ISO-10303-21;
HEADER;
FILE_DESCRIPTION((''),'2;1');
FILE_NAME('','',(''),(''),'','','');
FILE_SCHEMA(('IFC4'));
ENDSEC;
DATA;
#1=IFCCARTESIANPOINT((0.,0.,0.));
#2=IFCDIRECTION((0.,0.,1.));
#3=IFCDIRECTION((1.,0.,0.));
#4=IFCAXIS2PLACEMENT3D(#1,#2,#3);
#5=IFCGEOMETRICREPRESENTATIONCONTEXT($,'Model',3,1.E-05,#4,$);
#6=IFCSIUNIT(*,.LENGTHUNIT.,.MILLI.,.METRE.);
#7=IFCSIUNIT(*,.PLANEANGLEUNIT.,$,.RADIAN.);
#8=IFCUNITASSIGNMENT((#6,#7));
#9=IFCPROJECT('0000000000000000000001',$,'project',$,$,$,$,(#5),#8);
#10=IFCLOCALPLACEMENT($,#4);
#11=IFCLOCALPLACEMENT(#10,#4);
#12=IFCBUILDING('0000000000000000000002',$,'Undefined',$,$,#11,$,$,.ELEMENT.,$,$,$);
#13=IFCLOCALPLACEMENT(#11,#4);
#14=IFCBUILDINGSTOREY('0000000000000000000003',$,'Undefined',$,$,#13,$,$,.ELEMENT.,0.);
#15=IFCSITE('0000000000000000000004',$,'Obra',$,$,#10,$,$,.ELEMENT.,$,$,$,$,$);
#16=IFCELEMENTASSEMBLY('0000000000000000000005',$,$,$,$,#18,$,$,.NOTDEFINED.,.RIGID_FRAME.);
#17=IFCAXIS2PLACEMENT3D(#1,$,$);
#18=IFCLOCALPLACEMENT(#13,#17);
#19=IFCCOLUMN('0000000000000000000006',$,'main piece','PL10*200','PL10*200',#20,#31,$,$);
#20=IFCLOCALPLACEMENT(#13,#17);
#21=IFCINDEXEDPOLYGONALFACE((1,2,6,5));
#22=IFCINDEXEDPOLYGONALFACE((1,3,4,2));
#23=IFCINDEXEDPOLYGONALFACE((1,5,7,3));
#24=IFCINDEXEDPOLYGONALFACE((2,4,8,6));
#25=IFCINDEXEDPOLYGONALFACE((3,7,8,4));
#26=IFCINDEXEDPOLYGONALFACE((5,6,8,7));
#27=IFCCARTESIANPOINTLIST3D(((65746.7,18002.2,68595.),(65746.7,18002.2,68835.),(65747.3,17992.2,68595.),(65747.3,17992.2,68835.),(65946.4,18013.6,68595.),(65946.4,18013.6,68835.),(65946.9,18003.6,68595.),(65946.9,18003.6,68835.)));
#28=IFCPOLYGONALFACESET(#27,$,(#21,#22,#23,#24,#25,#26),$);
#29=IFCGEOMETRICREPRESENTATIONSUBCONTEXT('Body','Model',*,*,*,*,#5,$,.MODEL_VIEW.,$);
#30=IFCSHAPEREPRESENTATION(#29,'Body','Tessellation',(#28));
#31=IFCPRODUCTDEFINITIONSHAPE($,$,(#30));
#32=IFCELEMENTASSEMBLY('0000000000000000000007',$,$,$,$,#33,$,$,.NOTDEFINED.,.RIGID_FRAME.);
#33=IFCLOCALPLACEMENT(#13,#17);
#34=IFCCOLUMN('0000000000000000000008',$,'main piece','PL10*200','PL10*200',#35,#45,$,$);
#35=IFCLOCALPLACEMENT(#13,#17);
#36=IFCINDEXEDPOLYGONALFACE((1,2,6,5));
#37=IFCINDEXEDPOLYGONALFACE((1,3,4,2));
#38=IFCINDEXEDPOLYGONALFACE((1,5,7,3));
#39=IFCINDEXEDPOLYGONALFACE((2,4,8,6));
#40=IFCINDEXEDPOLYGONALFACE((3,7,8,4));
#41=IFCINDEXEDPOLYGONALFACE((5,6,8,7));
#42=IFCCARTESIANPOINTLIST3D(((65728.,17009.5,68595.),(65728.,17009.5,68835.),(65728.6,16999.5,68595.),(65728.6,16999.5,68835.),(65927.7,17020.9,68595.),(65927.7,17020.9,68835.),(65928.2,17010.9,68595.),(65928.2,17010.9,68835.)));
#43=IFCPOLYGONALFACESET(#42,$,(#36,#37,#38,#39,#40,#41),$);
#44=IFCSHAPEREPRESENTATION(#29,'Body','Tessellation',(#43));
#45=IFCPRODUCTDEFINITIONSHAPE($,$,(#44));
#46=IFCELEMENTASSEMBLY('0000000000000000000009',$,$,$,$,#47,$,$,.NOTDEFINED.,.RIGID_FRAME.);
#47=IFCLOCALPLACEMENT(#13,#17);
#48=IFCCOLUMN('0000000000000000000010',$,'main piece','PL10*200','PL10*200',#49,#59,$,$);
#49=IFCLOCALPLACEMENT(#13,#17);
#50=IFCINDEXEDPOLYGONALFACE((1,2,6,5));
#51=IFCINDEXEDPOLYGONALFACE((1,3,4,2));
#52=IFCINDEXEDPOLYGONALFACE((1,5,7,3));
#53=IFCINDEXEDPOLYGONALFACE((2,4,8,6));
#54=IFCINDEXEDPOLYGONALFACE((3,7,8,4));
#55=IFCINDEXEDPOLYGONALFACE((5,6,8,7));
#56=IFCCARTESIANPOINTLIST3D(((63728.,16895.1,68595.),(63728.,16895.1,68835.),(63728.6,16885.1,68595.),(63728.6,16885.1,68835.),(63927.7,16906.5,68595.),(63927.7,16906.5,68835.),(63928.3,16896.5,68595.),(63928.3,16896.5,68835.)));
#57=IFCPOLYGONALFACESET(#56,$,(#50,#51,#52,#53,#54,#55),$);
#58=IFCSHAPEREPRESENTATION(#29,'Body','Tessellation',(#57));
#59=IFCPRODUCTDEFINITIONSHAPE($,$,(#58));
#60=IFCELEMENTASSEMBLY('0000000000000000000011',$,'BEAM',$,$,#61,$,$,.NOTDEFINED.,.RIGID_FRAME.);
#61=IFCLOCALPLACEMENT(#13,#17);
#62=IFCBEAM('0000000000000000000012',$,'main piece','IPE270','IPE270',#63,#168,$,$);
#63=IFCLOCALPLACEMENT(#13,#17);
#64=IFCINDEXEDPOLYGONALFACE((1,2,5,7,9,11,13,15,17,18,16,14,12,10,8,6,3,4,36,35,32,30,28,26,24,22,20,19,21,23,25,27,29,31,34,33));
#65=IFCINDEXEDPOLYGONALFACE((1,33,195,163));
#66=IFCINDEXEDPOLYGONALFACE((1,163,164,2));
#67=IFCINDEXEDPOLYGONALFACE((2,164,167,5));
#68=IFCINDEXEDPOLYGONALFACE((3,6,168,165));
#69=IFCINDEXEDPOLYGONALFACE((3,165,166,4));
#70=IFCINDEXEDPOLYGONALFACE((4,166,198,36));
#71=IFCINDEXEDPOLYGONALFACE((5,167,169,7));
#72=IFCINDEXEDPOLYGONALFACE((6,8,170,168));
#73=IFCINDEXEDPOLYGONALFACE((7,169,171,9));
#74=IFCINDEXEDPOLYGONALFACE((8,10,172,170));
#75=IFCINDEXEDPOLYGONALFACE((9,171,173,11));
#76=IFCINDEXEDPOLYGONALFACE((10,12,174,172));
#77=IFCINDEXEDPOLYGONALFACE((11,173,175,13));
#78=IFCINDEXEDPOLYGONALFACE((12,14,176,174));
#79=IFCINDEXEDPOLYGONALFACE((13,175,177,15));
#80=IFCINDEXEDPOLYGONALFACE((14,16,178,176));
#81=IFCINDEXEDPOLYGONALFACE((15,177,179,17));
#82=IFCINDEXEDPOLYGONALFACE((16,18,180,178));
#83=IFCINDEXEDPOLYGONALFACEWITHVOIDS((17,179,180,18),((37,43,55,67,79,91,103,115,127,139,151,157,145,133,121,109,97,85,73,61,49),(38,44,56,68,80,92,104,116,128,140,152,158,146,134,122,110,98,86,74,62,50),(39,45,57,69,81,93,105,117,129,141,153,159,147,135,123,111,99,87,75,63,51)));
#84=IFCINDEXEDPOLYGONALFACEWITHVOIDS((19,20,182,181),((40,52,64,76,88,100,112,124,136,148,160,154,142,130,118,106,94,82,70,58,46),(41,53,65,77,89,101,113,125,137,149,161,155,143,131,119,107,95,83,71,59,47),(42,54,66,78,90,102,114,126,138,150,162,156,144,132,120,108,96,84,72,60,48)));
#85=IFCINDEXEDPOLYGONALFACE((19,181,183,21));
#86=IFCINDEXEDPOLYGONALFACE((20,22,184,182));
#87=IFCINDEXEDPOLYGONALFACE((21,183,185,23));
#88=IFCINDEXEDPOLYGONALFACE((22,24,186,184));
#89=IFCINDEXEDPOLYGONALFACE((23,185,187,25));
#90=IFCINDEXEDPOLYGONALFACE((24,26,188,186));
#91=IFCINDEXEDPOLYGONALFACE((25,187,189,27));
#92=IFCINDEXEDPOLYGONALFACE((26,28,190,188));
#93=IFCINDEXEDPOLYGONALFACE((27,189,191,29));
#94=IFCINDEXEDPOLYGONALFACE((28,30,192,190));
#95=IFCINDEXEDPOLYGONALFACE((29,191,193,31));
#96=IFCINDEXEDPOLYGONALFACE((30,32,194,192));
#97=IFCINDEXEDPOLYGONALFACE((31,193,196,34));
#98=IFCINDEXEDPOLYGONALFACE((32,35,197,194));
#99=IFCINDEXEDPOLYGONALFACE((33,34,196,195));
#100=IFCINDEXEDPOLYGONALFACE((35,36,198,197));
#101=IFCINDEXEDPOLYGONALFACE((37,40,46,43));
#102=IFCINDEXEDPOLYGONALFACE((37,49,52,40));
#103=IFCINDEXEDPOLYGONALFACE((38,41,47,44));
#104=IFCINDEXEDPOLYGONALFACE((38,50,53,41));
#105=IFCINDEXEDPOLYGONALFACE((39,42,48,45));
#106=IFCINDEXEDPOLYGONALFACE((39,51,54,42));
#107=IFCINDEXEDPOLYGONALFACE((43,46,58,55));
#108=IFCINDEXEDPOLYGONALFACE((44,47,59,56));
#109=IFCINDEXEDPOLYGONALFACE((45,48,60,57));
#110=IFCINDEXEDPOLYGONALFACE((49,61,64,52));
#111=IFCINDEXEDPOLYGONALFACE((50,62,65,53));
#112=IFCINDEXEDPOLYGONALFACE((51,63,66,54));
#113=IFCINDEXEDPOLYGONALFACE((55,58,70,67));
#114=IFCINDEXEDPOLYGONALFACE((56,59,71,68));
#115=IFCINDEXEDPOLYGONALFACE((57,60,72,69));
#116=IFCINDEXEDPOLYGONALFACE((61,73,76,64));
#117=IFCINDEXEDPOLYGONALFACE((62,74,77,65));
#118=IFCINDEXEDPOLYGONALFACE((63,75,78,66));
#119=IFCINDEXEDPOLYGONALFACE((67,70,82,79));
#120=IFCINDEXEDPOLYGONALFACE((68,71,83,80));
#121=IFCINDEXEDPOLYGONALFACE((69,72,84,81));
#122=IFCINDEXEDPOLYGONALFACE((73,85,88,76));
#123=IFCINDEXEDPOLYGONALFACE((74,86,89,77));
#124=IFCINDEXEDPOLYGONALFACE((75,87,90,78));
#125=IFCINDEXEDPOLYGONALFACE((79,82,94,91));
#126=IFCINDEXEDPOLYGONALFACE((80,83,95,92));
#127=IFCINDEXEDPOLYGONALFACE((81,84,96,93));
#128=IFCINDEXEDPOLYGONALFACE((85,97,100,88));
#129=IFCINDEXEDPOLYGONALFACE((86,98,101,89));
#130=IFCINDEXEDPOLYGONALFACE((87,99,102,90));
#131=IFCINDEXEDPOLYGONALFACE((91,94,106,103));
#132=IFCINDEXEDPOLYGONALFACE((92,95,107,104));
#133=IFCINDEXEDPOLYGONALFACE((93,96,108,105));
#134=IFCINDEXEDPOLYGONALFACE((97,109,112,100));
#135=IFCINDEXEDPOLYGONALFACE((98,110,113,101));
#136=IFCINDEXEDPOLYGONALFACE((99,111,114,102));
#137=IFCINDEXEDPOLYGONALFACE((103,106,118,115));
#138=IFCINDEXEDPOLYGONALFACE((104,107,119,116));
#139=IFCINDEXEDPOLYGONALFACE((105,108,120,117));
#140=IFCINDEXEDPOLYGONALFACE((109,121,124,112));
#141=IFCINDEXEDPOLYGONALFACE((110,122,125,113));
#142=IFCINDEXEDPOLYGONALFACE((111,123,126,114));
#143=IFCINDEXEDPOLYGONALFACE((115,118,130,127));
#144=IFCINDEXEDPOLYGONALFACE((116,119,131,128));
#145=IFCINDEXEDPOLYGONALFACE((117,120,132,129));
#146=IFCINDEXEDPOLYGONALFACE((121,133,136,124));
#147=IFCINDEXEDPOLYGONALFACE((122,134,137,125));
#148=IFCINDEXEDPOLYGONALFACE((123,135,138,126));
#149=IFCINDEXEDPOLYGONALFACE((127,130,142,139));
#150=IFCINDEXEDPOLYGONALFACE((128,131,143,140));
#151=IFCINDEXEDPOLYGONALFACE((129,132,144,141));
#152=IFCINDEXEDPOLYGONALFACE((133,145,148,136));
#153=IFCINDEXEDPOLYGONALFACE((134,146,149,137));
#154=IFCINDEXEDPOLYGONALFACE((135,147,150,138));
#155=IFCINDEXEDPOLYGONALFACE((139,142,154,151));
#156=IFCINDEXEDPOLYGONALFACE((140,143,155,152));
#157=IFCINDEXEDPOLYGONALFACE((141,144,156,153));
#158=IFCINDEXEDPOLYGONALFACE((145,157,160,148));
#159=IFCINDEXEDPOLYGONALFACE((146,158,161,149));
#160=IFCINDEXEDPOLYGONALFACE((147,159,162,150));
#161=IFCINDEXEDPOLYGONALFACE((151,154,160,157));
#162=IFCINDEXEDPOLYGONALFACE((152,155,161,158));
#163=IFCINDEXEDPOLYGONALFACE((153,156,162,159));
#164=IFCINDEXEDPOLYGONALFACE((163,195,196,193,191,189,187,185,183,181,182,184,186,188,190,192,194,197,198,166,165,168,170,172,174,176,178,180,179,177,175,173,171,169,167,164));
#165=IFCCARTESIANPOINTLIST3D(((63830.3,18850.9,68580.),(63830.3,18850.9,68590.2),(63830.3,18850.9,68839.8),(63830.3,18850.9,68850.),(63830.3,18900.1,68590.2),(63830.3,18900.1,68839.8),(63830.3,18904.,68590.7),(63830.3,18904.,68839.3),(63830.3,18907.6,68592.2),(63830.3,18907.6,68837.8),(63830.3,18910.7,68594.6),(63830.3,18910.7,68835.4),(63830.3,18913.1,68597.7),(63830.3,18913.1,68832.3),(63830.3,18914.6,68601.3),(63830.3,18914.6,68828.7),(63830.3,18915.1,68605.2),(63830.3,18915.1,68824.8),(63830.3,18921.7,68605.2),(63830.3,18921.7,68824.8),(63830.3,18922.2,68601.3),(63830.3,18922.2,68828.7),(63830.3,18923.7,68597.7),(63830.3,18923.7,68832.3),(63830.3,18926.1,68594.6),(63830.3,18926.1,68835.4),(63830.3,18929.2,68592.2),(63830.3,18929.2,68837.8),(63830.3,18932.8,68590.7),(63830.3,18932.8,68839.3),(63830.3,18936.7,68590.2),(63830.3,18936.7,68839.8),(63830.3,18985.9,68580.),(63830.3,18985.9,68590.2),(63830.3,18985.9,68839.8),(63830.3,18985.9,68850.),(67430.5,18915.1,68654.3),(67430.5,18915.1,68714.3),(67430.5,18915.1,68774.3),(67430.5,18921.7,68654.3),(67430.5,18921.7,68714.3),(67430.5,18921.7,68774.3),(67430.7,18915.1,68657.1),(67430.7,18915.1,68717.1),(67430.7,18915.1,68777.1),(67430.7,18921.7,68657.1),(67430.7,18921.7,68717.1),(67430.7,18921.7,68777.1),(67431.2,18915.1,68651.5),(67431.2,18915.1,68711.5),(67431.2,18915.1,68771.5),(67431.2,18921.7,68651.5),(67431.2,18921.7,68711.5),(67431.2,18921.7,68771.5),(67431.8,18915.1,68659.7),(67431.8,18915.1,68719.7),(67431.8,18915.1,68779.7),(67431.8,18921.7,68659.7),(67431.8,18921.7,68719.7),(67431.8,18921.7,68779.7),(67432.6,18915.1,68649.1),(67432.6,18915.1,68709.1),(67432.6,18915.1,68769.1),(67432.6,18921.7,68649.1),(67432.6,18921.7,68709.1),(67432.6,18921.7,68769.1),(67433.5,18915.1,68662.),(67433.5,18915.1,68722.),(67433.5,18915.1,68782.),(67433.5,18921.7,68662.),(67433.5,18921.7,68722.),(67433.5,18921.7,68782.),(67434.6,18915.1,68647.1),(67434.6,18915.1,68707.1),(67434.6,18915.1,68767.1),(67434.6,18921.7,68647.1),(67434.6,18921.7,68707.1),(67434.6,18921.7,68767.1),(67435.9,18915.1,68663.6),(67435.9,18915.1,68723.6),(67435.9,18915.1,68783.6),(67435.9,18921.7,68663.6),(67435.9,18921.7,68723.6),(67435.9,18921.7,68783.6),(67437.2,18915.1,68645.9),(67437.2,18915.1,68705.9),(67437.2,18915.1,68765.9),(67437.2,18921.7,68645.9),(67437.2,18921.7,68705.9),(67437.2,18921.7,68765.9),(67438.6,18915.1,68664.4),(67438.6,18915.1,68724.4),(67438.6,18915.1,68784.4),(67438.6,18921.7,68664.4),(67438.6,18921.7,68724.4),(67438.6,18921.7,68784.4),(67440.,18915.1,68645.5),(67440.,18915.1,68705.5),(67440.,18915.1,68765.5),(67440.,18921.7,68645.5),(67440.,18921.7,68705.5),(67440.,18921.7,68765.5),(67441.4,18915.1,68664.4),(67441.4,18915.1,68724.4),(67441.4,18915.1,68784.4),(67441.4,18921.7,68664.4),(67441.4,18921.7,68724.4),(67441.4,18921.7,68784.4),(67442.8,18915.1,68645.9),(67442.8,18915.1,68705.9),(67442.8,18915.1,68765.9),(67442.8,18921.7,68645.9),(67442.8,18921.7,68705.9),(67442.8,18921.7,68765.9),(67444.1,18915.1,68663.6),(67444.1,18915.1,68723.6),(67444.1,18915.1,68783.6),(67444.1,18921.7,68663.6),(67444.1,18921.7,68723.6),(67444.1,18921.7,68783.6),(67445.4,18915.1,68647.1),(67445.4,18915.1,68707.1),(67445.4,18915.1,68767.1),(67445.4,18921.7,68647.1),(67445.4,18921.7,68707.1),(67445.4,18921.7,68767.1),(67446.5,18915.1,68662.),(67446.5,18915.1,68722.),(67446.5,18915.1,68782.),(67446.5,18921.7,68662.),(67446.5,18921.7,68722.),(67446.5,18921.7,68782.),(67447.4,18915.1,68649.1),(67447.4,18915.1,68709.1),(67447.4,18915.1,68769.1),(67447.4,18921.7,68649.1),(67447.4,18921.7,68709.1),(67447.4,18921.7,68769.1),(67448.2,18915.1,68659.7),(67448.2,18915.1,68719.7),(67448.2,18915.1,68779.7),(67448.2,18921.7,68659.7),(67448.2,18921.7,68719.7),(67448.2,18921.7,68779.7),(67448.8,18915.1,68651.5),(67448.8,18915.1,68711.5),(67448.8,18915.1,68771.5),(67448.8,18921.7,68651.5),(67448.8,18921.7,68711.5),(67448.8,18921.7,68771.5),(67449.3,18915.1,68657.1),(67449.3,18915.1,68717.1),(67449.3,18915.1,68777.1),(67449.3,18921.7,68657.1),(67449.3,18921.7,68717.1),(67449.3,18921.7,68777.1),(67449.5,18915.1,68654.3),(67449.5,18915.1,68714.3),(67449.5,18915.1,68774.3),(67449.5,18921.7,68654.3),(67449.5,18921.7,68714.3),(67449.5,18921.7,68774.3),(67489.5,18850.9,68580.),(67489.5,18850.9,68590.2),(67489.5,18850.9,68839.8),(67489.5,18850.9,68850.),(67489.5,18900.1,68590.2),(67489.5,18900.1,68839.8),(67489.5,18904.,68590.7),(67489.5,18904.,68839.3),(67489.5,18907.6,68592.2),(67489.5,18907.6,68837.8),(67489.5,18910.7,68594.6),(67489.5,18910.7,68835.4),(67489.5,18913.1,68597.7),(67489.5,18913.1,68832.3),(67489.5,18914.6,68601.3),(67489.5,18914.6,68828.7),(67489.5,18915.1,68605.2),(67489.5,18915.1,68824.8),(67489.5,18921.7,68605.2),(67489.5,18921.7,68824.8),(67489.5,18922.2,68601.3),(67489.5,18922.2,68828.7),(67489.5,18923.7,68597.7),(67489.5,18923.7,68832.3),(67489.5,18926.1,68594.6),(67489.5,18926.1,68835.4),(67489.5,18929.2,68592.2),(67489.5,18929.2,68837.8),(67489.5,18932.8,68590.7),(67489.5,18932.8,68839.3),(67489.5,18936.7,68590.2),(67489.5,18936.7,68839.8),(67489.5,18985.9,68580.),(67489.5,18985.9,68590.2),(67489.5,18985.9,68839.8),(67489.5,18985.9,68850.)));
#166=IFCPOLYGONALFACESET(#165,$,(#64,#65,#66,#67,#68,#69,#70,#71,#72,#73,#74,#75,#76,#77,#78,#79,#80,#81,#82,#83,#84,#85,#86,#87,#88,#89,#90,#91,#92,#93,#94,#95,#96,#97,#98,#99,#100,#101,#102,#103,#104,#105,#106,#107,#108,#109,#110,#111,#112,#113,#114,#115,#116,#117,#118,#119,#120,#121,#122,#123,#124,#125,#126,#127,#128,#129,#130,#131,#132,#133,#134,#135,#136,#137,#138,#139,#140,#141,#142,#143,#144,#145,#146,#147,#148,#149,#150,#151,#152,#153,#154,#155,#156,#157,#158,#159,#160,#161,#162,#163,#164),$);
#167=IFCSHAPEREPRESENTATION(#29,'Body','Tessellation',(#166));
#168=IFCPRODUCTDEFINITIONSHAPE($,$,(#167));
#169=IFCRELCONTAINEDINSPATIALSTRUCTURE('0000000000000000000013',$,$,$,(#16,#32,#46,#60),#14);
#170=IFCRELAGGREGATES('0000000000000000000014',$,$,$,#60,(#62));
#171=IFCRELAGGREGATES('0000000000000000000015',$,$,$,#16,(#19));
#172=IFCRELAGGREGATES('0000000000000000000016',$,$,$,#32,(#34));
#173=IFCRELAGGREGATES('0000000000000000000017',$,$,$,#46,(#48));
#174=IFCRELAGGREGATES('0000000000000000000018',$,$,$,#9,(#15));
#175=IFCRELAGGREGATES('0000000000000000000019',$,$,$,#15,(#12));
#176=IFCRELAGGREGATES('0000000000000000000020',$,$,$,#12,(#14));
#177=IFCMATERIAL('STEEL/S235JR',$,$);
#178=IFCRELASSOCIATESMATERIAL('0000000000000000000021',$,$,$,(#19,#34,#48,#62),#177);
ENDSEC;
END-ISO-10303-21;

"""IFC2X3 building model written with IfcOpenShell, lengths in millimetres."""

from ifc_helpers import new_model, si_unit, frame, origin_with_axes, origin_2d_with_axis, place, context, subcontext, project, spatial, rectangle, circle, i_section, extrude, clip, halfspace, source, transform, mapped, material, element, aggregate, save


model = new_model("IFC2X3")

# Units and contexts
model_context = context("Model", 3, precision=1e-05, world=origin_with_axes())
body_context = subcontext(model_context, "Body", "Model", "MODEL_VIEW")
ifc_project = project(units=[si_unit("LENGTHUNIT", "METRE", prefix="MILLI"), si_unit("PLANEANGLEUNIT", "RADIAN")], contexts=[model_context])

# Site, building, storey
site_placement = place(None, origin_with_axes())
site = spatial("IfcSite", under=ifc_project, at=site_placement, Name="Obra", CompositionType="ELEMENT")
building_placement = place(site_placement, origin_with_axes())
building = spatial("IfcBuilding", under=site, at=building_placement, Name="Undefined", CompositionType="ELEMENT")
storey_placement = place(building_placement, origin_with_axes())
storey = spatial("IfcBuildingStorey", under=building, at=storey_placement, Name="Undefined", CompositionType="ELEMENT", Elevation=0.0)

# Element assemblies, columns
assembly_1_placement = place(storey_placement, origin_with_axes())
assembly_1 = element("IfcElementAssembly", 1, at=assembly_1_placement, inside=storey, AssemblyPlace="NOTDEFINED", PredefinedType="RIGID_FRAME")
ifc_material = material(Name="STEEL/S235JR")
column_1_placement = place(assembly_1_placement, frame((65846.8, 18002.9, 68595.0), z_axis=(0.0, 0.0, 1.0), x_axis=(0.998368, 0.057107, 0.0)))
column_1 = element("IfcColumn", 2, at=column_1_placement, material=ifc_material, Name="main piece", Description="PL10*200", ObjectType="PL10*200", context=body_context, shape_type="SweptSolid", body=[
    extrude(rectangle(XDim=10.0, YDim=200.0, at=origin_2d_with_axis()), frame((0.0, 0.0, 240.0), z_axis=(0.0, 0.0, -1.0), x_axis=(0.0, 1.0, 0.0)), (0.0, 0.0, 1.0), 240.0),
])
assembly_2_placement = place(storey_placement, origin_with_axes())
assembly_2 = element("IfcElementAssembly", 3, at=assembly_2_placement, inside=storey, AssemblyPlace="NOTDEFINED", PredefinedType="RIGID_FRAME")
column_2_placement = place(assembly_2_placement, frame((65828.1, 17010.2, 68595.0), z_axis=(0.0, 0.0, 1.0), x_axis=(-0.998368, -0.057107, 0.0)))
column_2 = element("IfcColumn", 4, at=column_2_placement, material=ifc_material, Name="main piece", Description="PL10*200", ObjectType="PL10*200", context=body_context, shape_type="SweptSolid", body=[
    extrude(rectangle(XDim=10.0, YDim=200.0, at=origin_2d_with_axis()), frame((0.0, 0.0, 240.0), z_axis=(0.0, 0.0, -1.0), x_axis=(0.0, 1.0, 0.0)), (0.0, 0.0, 1.0), 240.0),
])
assembly_3_placement = place(storey_placement, origin_with_axes())
assembly_3 = element("IfcElementAssembly", 5, at=assembly_3_placement, inside=storey, AssemblyPlace="NOTDEFINED", PredefinedType="RIGID_FRAME")
column_3_placement = place(assembly_3_placement, frame((63828.2, 16895.8, 68595.0), z_axis=(0.0, 0.0, 1.0), x_axis=(-0.998368, -0.057107, 0.0)))
column_3 = element("IfcColumn", 6, at=column_3_placement, material=ifc_material, Name="main piece", Description="PL10*200", ObjectType="PL10*200", context=body_context, shape_type="SweptSolid", body=[
    extrude(rectangle(XDim=10.0, YDim=200.0, at=origin_2d_with_axis()), frame((0.0, 0.0, 240.0), z_axis=(0.0, 0.0, -1.0), x_axis=(0.0, 1.0, 0.0)), (0.0, 0.0, 1.0), 240.0),
])

# Element assembly, beam, opening
assembly_4_placement = place(storey_placement, origin_with_axes())
assembly_4 = element("IfcElementAssembly", 7, at=assembly_4_placement, inside=storey, Name="BEAM", AssemblyPlace="NOTDEFINED", PredefinedType="RIGID_FRAME")
beam_1_placement = place(assembly_4_placement, frame((63830.3, 18918.4, 68715.0), z_axis=(0.0, 0.0, 1.0), x_axis=(1.0, 0.000001, 0.0)))
beam_1 = element("IfcBeam", 8, at=beam_1_placement, material=ifc_material, Name="main piece", Description="IPE270", ObjectType="IPE270", context=body_context, shape_type="Clipping", body=[
    clip(extrude(i_section(OverallWidth=135.0, OverallDepth=270.0, WebThickness=6.6, FlangeThickness=10.2, FilletRadius=15.0, at=origin_2d_with_axis()), frame((3910.9, 0.0, 0.0), z_axis=(-1.0, 0.0, 0.0), x_axis=(0.0, -1.0, 0.0)), (0.0, 0.0, 1.0), 3910.9), halfspace(frame((3659.2, -60.0, -120.0), z_axis=(1.0, 0.000017, 0.0), x_axis=(0.0, 0.0, 1.0)), False)),
])
shared_shape_1 = source(origin_with_axes(), body_context, "Body", "SweptSolid", [
    extrude(circle(Radius=9.5, at=origin_2d_with_axis()), frame((0.0, -3.4, 0.0), z_axis=(0.0, 1.0, 0.0), x_axis=(1.0, 0.0, 0.0)), (0.0, 0.0, 1.0), 6.8),
])
opening_1_placement = place(assembly_4_placement, frame((67490.0, 18918.4, 68835.0), z_axis=(-1.0, 0.0, 0.0), x_axis=(0.0, 0.0, -1.0)))
element("IfcOpeningElement", 9, at=opening_1_placement, cuts=beam_1, ObjectType="Opening", context=body_context, shape_type="MappedRepresentation", body=[
    mapped(shared_shape_1, transform((60.0, 0.0, 50.0))),
    mapped(shared_shape_1, transform((120.0, 0.0, 50.0))),
    mapped(shared_shape_1, transform((180.0, 0.0, 50.0))),
])

aggregate(assembly_4, [beam_1])
aggregate(assembly_1, [column_1])

aggregate(assembly_2, [column_2])
aggregate(assembly_3, [column_3])

save(model, "model.ifc")
